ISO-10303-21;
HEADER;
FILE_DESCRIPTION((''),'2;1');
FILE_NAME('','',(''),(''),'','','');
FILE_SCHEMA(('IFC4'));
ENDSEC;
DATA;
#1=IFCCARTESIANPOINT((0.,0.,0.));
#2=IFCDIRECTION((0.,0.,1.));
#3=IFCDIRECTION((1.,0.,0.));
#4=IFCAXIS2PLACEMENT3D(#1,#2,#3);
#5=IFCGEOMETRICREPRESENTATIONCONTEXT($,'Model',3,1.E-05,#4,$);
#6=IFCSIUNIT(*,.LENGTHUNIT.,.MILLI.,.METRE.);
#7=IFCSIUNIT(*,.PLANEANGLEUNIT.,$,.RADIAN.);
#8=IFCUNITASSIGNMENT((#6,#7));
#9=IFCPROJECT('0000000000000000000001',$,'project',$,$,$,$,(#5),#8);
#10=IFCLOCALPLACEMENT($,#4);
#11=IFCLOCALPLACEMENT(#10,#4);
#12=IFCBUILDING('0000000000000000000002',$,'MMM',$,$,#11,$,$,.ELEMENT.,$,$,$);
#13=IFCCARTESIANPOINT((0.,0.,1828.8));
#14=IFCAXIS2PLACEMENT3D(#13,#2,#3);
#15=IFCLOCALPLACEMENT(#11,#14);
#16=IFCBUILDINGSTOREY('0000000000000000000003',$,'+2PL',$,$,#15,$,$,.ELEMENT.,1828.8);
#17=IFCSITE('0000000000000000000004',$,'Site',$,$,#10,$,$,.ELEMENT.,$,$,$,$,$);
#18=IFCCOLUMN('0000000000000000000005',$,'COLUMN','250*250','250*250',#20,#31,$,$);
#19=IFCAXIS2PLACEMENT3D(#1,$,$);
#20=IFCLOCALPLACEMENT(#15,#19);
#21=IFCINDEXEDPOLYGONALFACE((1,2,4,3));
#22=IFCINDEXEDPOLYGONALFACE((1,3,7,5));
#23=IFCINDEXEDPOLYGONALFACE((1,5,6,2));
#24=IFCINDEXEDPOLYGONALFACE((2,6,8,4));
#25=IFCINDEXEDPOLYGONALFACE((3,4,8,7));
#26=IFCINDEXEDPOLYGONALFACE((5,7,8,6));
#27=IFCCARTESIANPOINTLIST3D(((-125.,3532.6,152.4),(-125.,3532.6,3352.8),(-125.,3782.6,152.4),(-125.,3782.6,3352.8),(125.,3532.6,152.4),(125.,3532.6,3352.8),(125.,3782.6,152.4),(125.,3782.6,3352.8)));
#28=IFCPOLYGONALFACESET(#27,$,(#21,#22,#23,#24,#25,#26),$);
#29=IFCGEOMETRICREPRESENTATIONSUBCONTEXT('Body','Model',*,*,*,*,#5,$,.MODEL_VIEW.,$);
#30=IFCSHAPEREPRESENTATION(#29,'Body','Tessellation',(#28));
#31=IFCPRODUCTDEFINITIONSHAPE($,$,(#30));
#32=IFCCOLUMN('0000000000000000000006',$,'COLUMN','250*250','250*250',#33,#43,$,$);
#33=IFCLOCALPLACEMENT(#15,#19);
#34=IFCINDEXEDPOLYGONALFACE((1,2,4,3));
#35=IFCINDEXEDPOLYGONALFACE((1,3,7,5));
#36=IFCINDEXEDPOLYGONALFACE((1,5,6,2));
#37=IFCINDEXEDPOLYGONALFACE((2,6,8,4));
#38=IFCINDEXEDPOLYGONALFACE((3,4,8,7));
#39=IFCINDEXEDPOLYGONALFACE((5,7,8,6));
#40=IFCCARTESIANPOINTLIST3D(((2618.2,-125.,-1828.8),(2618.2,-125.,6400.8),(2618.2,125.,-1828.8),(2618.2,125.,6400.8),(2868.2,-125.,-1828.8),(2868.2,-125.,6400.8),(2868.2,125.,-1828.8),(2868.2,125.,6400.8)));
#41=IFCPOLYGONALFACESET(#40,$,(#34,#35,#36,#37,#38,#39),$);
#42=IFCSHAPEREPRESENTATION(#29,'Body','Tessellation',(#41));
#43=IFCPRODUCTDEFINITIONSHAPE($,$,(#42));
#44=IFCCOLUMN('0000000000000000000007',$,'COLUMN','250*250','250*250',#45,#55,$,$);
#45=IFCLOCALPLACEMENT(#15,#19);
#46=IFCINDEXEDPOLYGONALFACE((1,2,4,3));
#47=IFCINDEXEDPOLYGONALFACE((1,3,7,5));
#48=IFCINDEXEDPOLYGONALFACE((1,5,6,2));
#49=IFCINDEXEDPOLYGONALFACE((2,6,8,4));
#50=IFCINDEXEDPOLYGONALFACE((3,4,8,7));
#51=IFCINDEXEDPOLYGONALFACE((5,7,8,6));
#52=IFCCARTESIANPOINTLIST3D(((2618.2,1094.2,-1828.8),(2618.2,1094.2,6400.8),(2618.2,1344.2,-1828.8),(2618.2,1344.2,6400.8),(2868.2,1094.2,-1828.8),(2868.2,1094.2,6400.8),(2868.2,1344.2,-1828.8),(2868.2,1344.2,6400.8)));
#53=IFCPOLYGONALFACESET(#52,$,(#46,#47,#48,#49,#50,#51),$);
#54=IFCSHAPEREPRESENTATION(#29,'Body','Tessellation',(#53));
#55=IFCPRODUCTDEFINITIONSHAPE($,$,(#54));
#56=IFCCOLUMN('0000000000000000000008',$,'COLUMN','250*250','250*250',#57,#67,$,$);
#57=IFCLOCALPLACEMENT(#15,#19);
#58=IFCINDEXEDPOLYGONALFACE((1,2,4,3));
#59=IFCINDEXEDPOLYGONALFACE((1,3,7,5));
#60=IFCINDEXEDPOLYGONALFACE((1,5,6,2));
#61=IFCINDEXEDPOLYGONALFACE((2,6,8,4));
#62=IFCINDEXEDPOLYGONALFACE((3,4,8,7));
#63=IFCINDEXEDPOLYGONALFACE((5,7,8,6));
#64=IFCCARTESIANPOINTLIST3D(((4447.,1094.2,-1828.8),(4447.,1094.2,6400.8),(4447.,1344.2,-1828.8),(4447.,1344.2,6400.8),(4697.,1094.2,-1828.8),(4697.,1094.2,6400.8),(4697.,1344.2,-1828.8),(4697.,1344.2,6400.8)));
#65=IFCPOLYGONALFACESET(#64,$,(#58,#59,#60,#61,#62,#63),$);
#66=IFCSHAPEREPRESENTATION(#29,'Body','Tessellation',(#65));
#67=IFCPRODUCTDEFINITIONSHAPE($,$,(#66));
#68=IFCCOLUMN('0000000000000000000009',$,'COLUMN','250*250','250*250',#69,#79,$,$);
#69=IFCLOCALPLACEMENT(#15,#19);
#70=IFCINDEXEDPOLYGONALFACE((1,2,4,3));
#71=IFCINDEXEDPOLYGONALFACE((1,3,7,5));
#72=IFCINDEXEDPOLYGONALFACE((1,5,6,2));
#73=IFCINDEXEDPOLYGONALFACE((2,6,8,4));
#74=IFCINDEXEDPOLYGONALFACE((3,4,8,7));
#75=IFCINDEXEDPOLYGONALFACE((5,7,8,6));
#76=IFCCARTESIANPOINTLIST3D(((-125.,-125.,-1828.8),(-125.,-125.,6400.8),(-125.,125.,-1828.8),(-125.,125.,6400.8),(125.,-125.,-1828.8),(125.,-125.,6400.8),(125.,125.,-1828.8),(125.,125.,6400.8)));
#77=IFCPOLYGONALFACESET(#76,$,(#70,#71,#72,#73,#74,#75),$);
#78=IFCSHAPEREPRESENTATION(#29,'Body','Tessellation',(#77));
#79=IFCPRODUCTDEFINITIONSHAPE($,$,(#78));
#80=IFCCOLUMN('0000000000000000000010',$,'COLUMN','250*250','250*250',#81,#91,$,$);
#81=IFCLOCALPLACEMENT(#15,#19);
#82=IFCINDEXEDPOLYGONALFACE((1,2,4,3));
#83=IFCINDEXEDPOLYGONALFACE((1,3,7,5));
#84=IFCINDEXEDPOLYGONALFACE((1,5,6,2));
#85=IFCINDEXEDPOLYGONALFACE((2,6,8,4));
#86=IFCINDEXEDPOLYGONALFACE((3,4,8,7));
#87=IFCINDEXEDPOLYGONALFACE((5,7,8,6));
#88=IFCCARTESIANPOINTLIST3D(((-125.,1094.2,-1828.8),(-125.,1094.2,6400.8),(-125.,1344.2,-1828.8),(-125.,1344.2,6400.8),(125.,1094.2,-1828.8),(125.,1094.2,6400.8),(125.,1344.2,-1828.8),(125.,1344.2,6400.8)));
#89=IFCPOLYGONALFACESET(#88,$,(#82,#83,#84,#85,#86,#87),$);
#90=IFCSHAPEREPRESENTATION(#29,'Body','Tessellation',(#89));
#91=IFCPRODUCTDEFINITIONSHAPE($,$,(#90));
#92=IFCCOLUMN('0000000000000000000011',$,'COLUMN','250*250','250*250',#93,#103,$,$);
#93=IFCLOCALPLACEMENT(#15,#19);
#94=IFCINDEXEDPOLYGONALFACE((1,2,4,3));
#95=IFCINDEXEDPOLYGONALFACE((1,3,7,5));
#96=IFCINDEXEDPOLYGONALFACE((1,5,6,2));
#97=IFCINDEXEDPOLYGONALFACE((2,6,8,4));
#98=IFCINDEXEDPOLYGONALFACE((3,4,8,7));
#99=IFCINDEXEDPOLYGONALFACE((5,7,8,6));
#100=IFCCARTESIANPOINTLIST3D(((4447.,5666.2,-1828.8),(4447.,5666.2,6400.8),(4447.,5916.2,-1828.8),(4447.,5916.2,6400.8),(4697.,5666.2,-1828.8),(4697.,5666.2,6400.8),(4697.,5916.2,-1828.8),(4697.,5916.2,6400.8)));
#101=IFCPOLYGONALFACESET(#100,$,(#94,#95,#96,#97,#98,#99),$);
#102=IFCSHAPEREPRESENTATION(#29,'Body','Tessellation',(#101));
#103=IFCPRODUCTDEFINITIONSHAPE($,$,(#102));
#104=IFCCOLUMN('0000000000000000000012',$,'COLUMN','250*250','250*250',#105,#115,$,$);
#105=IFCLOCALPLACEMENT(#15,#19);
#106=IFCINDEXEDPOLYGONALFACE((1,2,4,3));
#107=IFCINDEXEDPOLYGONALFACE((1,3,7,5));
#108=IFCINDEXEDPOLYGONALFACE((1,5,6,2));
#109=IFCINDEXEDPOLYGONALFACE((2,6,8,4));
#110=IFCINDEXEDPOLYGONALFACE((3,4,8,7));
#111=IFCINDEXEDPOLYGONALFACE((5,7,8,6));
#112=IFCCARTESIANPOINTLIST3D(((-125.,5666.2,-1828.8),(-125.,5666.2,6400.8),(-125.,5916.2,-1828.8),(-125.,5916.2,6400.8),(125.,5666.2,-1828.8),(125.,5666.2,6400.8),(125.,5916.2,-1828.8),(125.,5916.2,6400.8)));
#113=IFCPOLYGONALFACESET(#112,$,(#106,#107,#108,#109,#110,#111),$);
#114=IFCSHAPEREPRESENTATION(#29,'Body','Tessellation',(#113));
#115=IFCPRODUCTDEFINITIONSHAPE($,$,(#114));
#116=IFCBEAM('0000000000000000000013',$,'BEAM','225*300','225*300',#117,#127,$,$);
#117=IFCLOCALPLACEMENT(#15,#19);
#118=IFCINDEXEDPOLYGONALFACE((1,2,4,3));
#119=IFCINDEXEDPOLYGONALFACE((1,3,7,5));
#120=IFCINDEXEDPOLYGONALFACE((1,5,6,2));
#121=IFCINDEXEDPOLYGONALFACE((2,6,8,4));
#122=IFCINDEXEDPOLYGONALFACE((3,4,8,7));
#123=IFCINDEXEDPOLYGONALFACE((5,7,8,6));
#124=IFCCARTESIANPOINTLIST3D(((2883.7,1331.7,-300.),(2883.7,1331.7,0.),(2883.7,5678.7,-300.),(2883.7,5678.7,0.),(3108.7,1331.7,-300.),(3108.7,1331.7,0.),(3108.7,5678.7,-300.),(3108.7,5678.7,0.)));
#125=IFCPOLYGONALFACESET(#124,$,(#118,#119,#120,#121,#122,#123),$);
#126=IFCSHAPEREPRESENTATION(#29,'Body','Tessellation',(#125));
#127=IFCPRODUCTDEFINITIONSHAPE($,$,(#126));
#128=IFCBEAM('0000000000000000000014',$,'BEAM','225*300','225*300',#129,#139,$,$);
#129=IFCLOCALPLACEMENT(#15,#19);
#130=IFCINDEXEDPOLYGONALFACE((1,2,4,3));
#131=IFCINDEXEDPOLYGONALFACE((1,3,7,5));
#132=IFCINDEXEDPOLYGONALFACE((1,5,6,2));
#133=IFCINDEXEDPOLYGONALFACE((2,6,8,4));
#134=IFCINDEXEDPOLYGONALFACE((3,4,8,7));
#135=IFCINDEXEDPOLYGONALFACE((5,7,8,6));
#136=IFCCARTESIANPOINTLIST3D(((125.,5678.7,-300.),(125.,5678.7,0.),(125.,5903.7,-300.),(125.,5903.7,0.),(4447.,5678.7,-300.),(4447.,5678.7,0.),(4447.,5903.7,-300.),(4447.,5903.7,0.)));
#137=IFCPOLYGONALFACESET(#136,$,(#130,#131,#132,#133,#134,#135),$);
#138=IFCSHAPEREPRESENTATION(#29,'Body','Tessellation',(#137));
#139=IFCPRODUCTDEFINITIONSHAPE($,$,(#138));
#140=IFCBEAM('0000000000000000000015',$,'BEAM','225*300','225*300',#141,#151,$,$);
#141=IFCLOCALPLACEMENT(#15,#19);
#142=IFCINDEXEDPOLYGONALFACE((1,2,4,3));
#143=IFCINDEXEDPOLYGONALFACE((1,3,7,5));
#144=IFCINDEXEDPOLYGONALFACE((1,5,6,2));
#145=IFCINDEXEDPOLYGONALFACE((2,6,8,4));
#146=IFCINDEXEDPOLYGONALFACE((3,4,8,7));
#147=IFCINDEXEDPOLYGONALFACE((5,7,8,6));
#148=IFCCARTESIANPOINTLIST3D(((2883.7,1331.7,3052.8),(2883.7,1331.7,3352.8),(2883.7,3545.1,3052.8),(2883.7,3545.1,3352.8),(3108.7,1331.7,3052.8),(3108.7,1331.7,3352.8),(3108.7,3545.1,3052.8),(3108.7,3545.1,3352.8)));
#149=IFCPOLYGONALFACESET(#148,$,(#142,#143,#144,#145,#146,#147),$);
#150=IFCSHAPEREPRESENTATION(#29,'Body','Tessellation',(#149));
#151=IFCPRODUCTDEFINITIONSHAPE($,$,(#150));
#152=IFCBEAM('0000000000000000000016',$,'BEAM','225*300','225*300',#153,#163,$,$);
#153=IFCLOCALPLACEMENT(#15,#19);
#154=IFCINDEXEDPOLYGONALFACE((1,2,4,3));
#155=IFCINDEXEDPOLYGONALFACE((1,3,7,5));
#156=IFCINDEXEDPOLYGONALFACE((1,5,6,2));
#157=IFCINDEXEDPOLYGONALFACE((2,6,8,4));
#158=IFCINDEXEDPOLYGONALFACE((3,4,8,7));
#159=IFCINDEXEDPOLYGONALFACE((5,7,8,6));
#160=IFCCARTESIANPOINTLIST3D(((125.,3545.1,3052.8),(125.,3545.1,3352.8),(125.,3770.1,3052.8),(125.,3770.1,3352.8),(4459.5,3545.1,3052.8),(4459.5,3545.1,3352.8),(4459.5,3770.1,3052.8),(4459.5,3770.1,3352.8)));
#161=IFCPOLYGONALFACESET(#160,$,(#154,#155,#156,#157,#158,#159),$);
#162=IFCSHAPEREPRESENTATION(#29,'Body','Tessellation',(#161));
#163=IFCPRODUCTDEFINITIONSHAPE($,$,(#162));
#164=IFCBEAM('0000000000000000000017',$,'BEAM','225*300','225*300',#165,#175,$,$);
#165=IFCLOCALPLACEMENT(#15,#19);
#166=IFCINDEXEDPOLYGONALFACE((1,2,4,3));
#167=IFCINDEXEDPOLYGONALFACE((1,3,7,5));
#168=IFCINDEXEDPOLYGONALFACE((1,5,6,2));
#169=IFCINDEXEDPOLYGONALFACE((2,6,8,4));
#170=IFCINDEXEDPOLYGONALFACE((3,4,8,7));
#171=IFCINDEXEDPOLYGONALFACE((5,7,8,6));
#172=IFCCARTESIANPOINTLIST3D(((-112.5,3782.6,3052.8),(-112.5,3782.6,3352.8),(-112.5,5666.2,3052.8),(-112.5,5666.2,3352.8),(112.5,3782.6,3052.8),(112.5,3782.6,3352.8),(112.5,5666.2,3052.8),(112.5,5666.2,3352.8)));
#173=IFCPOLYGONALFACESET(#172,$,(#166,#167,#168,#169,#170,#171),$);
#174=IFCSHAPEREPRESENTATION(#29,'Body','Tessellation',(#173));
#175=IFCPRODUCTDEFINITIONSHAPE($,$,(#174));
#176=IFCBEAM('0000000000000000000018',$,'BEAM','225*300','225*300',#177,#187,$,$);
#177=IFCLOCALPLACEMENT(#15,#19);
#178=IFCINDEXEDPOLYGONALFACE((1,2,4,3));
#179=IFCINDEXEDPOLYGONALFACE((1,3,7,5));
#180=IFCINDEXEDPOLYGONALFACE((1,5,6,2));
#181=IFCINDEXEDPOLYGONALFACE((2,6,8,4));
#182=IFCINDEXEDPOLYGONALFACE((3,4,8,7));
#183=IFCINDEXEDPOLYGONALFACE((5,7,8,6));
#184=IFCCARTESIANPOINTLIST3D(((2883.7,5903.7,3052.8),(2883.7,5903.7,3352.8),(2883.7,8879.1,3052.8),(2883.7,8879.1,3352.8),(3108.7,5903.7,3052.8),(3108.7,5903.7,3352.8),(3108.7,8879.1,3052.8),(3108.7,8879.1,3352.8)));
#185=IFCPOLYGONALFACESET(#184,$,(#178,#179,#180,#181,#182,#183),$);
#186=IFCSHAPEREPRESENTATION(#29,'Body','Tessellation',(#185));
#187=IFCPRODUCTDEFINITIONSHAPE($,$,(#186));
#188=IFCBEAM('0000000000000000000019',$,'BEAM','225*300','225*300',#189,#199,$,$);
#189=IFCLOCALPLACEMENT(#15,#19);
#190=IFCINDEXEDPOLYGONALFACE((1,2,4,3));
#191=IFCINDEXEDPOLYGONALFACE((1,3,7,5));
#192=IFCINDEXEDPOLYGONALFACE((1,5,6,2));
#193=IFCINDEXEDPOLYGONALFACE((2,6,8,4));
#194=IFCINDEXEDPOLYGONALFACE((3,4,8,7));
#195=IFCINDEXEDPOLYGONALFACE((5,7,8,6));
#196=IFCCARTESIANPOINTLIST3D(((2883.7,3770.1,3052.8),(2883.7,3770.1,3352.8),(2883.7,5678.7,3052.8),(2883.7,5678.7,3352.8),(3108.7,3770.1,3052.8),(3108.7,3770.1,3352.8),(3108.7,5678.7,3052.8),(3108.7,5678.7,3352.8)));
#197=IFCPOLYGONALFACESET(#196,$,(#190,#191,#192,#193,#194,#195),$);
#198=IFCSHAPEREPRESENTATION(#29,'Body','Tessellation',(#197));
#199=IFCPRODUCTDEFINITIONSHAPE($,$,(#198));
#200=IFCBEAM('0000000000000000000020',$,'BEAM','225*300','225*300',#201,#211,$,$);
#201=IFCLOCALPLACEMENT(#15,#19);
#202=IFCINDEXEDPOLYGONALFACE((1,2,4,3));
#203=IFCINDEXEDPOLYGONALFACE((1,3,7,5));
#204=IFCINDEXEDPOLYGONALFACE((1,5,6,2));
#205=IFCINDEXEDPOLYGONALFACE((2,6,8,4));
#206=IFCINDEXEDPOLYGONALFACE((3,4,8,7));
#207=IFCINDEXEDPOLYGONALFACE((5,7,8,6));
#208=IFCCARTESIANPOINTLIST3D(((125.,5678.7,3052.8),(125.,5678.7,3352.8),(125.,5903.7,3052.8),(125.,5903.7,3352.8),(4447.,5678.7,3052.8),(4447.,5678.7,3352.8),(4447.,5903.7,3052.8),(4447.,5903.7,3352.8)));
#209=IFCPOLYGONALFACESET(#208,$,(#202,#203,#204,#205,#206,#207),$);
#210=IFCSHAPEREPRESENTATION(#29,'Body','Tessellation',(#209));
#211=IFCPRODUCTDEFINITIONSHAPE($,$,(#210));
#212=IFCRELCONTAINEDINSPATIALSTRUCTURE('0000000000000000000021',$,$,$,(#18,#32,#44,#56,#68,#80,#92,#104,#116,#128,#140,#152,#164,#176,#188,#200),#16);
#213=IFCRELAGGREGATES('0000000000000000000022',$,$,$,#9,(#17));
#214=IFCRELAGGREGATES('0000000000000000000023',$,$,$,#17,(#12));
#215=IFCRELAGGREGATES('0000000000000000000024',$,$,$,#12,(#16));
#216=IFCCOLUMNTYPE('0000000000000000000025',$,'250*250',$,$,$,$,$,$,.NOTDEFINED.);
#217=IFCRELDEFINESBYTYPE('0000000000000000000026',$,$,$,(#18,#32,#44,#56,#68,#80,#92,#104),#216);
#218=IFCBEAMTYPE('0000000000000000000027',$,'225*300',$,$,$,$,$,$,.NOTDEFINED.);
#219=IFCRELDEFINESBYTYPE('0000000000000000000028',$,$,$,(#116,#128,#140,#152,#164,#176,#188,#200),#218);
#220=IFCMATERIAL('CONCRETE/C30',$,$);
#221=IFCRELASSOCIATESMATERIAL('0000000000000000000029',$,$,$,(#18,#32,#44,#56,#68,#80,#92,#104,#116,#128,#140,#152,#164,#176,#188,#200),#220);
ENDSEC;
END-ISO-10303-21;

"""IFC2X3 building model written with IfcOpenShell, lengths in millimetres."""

from ifc_helpers import new_model, si_unit, frame, origin_with_axes, origin_2d_with_axis, place, context, subcontext, project, spatial, rectangle, extrude, material, type_object, element, save


model = new_model("IFC2X3")

# Units and contexts
model_context = context("Model", 3, precision=1e-05, world=origin_with_axes())
body_context = subcontext(model_context, "Body", "Model", "MODEL_VIEW")
ifc_project = project(units=[si_unit("LENGTHUNIT", "METRE", prefix="MILLI"), si_unit("PLANEANGLEUNIT", "RADIAN")], contexts=[model_context])

# Site, building, storey
site_placement = place(None, origin_with_axes())
site = spatial("IfcSite", under=ifc_project, at=site_placement, Name="Site", CompositionType="ELEMENT")
building_placement = place(site_placement, origin_with_axes())
building = spatial("IfcBuilding", under=site, at=building_placement, Name="MMM", CompositionType="ELEMENT")
storey_placement = place(building_placement, frame((0.0, 0.0, 1828.8), z_axis=(0.0, 0.0, 1.0), x_axis=(1.0, 0.0, 0.0)))
storey = spatial("IfcBuildingStorey", under=building, at=storey_placement, Name="+2PL", CompositionType="ELEMENT", Elevation=1828.8)

# Columns
ifc_material = material(Name="CONCRETE/C30")
column_type = type_object("IfcColumnType", Name="250*250", PredefinedType="NOTDEFINED")
column_placement = place(storey_placement, frame((0.0, 3657.6, 152.4), z_axis=(0.0, 0.0, 1.0), x_axis=(0.0, 1.0, 0.0)))
element("IfcColumn", 1, at=column_placement, inside=storey, type_object=column_type, material=ifc_material, Name="COLUMN", Description="250*250", ObjectType="250*250", context=body_context, shape_type="SweptSolid", body=[
    extrude(rectangle(XDim=250.0, YDim=250.0, at=origin_2d_with_axis()), frame((0.0, 0.0, 3200.4), z_axis=(0.0, 0.0, -1.0), x_axis=(0.0, 1.0, 0.0)), (0.0, 0.0, 1.0), 3200.4),
])
for number, where, z_axis, x_axis, name in (
    (2, (2743.2, 0.0, -1828.8), (0.0, 0.0, 1.0), (0.0, 1.0, 0.0), "COLUMN"),
    (3, (2743.2, 1219.2, -1828.8), (0.0, 0.0, 1.0), (0.0, 1.0, 0.0), "COLUMN"),
    (4, (4572.0, 1219.2, -1828.8), (0.0, 0.0, 1.0), (0.0, 1.0, 0.0), "COLUMN"),
    (5, (0.0, 0.0, -1828.8), (0.0, 0.0, 1.0), (0.0, 1.0, 0.0), "COLUMN"),
    (6, (0.0, 1219.2, -1828.8), (0.0, 0.0, 1.0), (0.0, 1.0, 0.0), "COLUMN"),
    (7, (4572.0, 5791.2, -1828.8), (0.0, 0.0, 1.0), (0.0, 1.0, 0.0), "COLUMN"),
    (8, (0.0, 5791.2, -1828.8), (0.0, 0.0, 1.0), (0.0, 1.0, 0.0), "COLUMN"),
):
    element("IfcColumn", number, at=place(storey_placement, frame(where, z_axis=z_axis, x_axis=x_axis)), inside=storey, type_object=column_type, material=ifc_material, Name=name, Description="250*250", ObjectType="250*250", context=body_context, shape_type="SweptSolid", body=[
        extrude(rectangle(XDim=250.0, YDim=250.0, at=origin_2d_with_axis()), frame((0.0, 0.0, 8229.6), z_axis=(0.0, 0.0, -1.0), x_axis=(0.0, 1.0, 0.0)), (0.0, 0.0, 1.0), 8229.6),
    ])

# Beams
beam_type_1 = type_object("IfcBeamType", Name="225*300", PredefinedType="NOTDEFINED")
beam_1_placement = place(storey_placement, frame((2996.2, 1331.7, -150.0), z_axis=(0.0, 0.0, 1.0), x_axis=(0.0, 1.0, 0.0)))
element("IfcBeam", 9, at=beam_1_placement, inside=storey, type_object=beam_type_1, material=ifc_material, Name="BEAM", Description="225*300", ObjectType="225*300", context=body_context, shape_type="SweptSolid", body=[
    extrude(rectangle(XDim=225.0, YDim=300.0, at=origin_2d_with_axis()), frame((4347.0, 0.0, 0.0), z_axis=(-1.0, 0.0, 0.0), x_axis=(0.0, -1.0, 0.0)), (0.0, 0.0, 1.0), 4347.0),
])
beam_2_placement = place(storey_placement, frame((125.0, 5791.2, -150.0), z_axis=(0.0, 0.0, 1.0), x_axis=(1.0, 0.0, 0.0)))
element("IfcBeam", 10, at=beam_2_placement, inside=storey, type_object=beam_type_1, material=ifc_material, Name="BEAM", Description="225*300", ObjectType="225*300", context=body_context, shape_type="SweptSolid", body=[
    extrude(rectangle(XDim=225.0, YDim=300.0, at=origin_2d_with_axis()), frame((4322.0, 0.0, 0.0), z_axis=(-1.0, 0.0, 0.0), x_axis=(0.0, -1.0, 0.0)), (0.0, 0.0, 1.0), 4322.0),
])
beam_3_placement = place(storey_placement, frame((2996.2, 1331.7, 3202.8), z_axis=(0.0, 0.0, 1.0), x_axis=(0.0, 1.0, 0.0)))
element("IfcBeam", 11, at=beam_3_placement, inside=storey, type_object=beam_type_1, material=ifc_material, Name="BEAM", Description="225*300", ObjectType="225*300", context=body_context, shape_type="SweptSolid", body=[
    extrude(rectangle(XDim=225.0, YDim=300.0, at=origin_2d_with_axis()), frame((2213.4, 0.0, 0.0), z_axis=(-1.0, 0.0, 0.0), x_axis=(0.0, -1.0, 0.0)), (0.0, 0.0, 1.0), 2213.4),
])
beam_4_placement = place(storey_placement, frame((125.0, 3657.6, 3202.8), z_axis=(0.0, 0.0, 1.0), x_axis=(1.0, 0.0, 0.0)))
element("IfcBeam", 12, at=beam_4_placement, inside=storey, type_object=beam_type_1, material=ifc_material, Name="BEAM", Description="225*300", ObjectType="225*300", context=body_context, shape_type="SweptSolid", body=[
    extrude(rectangle(XDim=225.0, YDim=300.0, at=origin_2d_with_axis()), frame((4334.5, 0.0, 0.0), z_axis=(-1.0, 0.0, 0.0), x_axis=(0.0, -1.0, 0.0)), (0.0, 0.0, 1.0), 4334.5),
])
beam_5_placement = place(storey_placement, frame((0.0, 3782.6, 3202.8), z_axis=(0.0, 0.0, 1.0), x_axis=(0.0, 1.0, 0.0)))
element("IfcBeam", 13, at=beam_5_placement, inside=storey, type_object=beam_type_1, material=ifc_material, Name="BEAM", Description="225*300", ObjectType="225*300", context=body_context, shape_type="SweptSolid", body=[
    extrude(rectangle(XDim=225.0, YDim=300.0, at=origin_2d_with_axis()), frame((1883.6, 0.0, 0.0), z_axis=(-1.0, 0.0, 0.0), x_axis=(0.0, -1.0, 0.0)), (0.0, 0.0, 1.0), 1883.6),
])
beam_6_placement = place(storey_placement, frame((2996.2, 5903.7, 3202.8), z_axis=(0.0, 0.0, 1.0), x_axis=(0.0, 1.0, 0.0)))
element("IfcBeam", 14, at=beam_6_placement, inside=storey, type_object=beam_type_1, material=ifc_material, Name="BEAM", Description="225*300", ObjectType="225*300", context=body_context, shape_type="SweptSolid", body=[
    extrude(rectangle(XDim=225.0, YDim=300.0, at=origin_2d_with_axis()), frame((2975.4, 0.0, 0.0), z_axis=(-1.0, 0.0, 0.0), x_axis=(0.0, -1.0, 0.0)), (0.0, 0.0, 1.0), 2975.4),
])
beam_7_placement = place(storey_placement, frame((2996.2, 3770.1, 3202.8), z_axis=(0.0, 0.0, 1.0), x_axis=(0.0, 1.0, 0.0)))
element("IfcBeam", 15, at=beam_7_placement, inside=storey, type_object=beam_type_1, material=ifc_material, Name="BEAM", Description="225*300", ObjectType="225*300", context=body_context, shape_type="SweptSolid", body=[
    extrude(rectangle(XDim=225.0, YDim=300.0, at=origin_2d_with_axis()), frame((1908.6, 0.0, 0.0), z_axis=(-1.0, 0.0, 0.0), x_axis=(0.0, -1.0, 0.0)), (0.0, 0.0, 1.0), 1908.6),
])
beam_8_placement = place(storey_placement, frame((125.0, 5791.2, 3202.8), z_axis=(0.0, 0.0, 1.0), x_axis=(1.0, 0.0, 0.0)))
element("IfcBeam", 16, at=beam_8_placement, inside=storey, type_object=beam_type_1, material=ifc_material, Name="BEAM", Description="225*300", ObjectType="225*300", context=body_context, shape_type="SweptSolid", body=[
    extrude(rectangle(XDim=225.0, YDim=300.0, at=origin_2d_with_axis()), frame((4322.0, 0.0, 0.0), z_axis=(-1.0, 0.0, 0.0), x_axis=(0.0, -1.0, 0.0)), (0.0, 0.0, 1.0), 4322.0),
])

save(model, "model.ifc")
